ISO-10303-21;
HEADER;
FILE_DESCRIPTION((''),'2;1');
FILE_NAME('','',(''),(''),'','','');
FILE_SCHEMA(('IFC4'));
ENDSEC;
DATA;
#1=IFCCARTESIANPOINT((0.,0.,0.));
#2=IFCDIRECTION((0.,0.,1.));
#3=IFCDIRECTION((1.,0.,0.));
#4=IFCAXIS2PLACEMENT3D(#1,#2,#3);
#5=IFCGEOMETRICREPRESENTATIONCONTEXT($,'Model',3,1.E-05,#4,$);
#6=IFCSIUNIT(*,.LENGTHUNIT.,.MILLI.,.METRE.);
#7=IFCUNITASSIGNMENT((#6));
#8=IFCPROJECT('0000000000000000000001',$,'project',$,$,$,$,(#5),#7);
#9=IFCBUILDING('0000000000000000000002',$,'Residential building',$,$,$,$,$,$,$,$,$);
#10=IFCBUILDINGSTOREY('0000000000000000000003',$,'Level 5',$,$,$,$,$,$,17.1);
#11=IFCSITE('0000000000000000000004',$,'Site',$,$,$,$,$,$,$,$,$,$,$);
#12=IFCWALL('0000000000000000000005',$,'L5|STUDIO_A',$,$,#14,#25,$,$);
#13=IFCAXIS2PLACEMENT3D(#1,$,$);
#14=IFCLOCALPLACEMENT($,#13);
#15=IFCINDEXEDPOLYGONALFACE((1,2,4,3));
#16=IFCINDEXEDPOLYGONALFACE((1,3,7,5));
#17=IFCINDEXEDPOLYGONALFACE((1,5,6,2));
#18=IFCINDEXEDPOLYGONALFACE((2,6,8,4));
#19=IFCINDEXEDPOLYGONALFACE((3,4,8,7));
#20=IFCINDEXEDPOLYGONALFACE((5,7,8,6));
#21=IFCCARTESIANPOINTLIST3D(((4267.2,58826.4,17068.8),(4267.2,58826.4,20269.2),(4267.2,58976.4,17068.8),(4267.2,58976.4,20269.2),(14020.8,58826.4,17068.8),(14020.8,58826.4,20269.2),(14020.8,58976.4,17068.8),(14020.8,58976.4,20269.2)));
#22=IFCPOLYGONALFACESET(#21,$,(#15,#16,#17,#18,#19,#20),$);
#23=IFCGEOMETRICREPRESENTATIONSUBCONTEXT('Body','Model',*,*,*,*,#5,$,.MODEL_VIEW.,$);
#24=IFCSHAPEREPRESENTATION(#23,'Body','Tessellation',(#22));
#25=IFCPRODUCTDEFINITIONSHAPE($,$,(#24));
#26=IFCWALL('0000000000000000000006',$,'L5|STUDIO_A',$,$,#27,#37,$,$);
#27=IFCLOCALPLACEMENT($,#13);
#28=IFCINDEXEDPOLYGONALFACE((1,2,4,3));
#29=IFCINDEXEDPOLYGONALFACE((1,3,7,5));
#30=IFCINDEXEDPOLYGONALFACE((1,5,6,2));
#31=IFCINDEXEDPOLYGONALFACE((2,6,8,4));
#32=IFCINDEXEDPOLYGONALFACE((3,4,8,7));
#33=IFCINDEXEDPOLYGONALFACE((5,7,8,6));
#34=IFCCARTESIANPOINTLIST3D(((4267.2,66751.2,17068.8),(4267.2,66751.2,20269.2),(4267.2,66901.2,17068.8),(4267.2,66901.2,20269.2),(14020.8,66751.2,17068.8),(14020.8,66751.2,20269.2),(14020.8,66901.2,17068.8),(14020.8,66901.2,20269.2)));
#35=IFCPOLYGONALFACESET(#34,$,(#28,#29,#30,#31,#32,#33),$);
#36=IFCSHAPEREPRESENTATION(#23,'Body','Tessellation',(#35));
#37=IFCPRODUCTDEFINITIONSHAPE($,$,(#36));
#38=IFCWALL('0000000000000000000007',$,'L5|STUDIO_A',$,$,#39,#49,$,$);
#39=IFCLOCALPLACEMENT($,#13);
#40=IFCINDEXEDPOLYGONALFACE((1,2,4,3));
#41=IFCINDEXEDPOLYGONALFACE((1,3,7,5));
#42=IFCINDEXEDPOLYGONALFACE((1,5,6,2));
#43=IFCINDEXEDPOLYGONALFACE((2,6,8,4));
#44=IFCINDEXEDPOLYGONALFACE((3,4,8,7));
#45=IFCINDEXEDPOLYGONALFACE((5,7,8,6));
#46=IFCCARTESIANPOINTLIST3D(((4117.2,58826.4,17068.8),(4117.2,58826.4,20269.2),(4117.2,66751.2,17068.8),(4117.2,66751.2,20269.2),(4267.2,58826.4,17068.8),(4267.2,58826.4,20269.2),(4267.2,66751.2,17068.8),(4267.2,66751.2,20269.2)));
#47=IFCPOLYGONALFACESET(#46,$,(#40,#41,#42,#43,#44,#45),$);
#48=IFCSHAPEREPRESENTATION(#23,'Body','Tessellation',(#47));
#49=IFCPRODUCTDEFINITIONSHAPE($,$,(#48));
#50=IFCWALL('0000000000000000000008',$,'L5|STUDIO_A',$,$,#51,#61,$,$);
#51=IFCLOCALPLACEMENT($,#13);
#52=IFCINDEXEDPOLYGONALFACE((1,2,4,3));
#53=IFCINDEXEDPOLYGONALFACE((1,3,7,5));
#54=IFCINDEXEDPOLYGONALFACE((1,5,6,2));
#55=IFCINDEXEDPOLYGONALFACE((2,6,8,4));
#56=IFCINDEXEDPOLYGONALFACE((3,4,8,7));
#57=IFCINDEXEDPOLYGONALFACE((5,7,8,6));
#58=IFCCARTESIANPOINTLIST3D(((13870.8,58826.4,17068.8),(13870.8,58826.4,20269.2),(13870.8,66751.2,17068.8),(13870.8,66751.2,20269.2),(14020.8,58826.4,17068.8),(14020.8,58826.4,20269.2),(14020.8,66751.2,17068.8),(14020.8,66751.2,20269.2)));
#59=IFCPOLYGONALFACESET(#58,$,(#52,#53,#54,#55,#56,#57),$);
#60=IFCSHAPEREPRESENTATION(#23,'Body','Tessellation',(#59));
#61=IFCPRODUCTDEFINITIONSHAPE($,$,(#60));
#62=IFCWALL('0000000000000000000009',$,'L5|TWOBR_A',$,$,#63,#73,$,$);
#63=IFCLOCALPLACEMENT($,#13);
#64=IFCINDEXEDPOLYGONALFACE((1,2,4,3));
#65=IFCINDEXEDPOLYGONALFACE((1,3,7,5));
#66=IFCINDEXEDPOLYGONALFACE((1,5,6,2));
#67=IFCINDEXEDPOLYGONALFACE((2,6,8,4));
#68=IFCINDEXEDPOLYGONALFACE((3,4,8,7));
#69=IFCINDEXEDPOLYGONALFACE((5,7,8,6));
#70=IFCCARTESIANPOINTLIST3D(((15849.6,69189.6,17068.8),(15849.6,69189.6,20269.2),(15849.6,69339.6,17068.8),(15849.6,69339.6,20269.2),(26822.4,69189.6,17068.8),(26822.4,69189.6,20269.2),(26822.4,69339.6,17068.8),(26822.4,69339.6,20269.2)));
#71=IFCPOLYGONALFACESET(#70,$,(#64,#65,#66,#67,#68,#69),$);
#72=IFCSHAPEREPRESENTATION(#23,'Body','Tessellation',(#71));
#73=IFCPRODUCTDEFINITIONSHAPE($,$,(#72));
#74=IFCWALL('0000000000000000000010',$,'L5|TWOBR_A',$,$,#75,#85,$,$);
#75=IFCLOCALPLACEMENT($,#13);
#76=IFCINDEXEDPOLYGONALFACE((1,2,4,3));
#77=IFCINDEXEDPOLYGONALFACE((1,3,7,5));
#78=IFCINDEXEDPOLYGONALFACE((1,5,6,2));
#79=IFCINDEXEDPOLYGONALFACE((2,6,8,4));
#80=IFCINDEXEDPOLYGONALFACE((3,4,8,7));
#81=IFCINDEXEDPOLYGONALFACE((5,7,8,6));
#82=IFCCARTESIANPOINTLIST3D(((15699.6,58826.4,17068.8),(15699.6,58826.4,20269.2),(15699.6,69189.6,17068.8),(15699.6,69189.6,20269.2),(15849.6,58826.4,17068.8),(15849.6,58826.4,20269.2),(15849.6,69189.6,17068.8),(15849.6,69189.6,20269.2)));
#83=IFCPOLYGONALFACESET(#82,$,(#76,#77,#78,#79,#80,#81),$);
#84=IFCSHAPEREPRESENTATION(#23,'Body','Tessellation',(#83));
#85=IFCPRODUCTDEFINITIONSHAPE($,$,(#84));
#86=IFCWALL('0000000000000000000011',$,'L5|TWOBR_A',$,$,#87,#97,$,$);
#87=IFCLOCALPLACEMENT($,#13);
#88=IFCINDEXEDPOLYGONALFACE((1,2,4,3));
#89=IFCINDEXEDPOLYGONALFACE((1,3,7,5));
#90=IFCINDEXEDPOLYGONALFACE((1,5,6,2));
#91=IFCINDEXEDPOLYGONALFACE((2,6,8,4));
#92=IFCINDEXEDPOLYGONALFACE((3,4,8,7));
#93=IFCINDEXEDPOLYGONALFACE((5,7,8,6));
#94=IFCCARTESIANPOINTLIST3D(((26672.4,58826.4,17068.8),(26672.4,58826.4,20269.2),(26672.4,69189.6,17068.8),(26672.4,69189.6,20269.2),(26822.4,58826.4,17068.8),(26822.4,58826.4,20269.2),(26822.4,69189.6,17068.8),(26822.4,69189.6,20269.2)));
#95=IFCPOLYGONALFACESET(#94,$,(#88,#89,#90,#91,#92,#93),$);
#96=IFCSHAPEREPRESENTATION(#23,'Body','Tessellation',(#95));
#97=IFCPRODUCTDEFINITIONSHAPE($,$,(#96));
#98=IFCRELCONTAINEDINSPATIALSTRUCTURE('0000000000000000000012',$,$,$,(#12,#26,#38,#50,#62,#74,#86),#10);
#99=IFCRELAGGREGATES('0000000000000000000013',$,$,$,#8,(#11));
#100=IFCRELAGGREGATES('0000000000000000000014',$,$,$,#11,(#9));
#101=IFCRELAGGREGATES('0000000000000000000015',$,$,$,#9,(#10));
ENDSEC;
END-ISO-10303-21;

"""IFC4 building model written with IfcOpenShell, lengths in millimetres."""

from ifc_helpers import new_model, si_unit, frame, origin_with_axes, place, context, subcontext, project, spatial, indexed_curve, outline, extrude, element, save


model = new_model("IFC4")

# Units and contexts
model_context = context("Model", 3, precision=1e-05, world=origin_with_axes())
body_context = subcontext(model_context, "Body", "Model", "MODEL_VIEW")
ifc_project = project(units=[si_unit("LENGTHUNIT", "METRE", prefix="MILLI")], contexts=[model_context])

# Site, building, storey
site = spatial("IfcSite", under=ifc_project, Name="Site")
building = spatial("IfcBuilding", under=site, Name="Residential building")
storey = spatial("IfcBuildingStorey", under=building, Name="Level 5", Elevation=17.1)

# Walls
for number, where, z_axis, x_axis, name in (
    (1, (4267.2, 58826.4, 17068.8), (0.0, 0.0, 1.0), (1.0, 0.0, 0.0), "L5|STUDIO_A"),
    (2, (4267.2, 66751.2, 17068.8), (0.0, 0.0, 1.0), (1.0, 0.0, 0.0), "L5|STUDIO_A"),
):
    element("IfcWall", number, at=place(None, frame(where, z_axis=z_axis, x_axis=x_axis)), inside=storey, Name=name, context=body_context, shape_type="SweptSolid", body=[
        extrude(outline(indexed_curve([(0.0, 0.0), (0.0, 150.0), (9753.6, 150.0), (9753.6, 0.0), (0.0, 0.0)], self_intersect=False)), origin_with_axes(), (0.0, 0.0, 1.0), 3200.4),
    ])
for number, where, z_axis, x_axis, name in (
    (3, (4267.2, 58826.4, 17068.8), (0.0, 0.0, 1.0), (0.0, 1.0, 0.0), "L5|STUDIO_A"),
    (4, (14020.8, 58826.4, 17068.8), (0.0, 0.0, 1.0), (0.0, 1.0, 0.0), "L5|STUDIO_A"),
):
    element("IfcWall", number, at=place(None, frame(where, z_axis=z_axis, x_axis=x_axis)), inside=storey, Name=name, context=body_context, shape_type="SweptSolid", body=[
        extrude(outline(indexed_curve([(0.0, 0.0), (0.0, 150.0), (7924.8, 150.0), (7924.8, 0.0), (0.0, 0.0)], self_intersect=False)), origin_with_axes(), (0.0, 0.0, 1.0), 3200.4),
    ])
for number, where, z_axis, x_axis, name in (
    (5, (15849.6, 69189.6, 17068.8), (0.0, 0.0, 1.0), (1.0, 0.0, 0.0), "L5|TWOBR_A"),
):
    element("IfcWall", number, at=place(None, frame(where, z_axis=z_axis, x_axis=x_axis)), inside=storey, Name=name, context=body_context, shape_type="SweptSolid", body=[
        extrude(outline(indexed_curve([(0.0, 0.0), (0.0, 150.0), (10972.8, 150.0), (10972.8, 0.0), (0.0, 0.0)], self_intersect=False)), origin_with_axes(), (0.0, 0.0, 1.0), 3200.4),
    ])
for number, where, z_axis, x_axis, name in (
    (6, (15849.6, 58826.4, 17068.8), (0.0, 0.0, 1.0), (0.0, 1.0, 0.0), "L5|TWOBR_A"),
    (7, (26822.4, 58826.4, 17068.8), (0.0, 0.0, 1.0), (0.0, 1.0, 0.0), "L5|TWOBR_A"),
):
    element("IfcWall", number, at=place(None, frame(where, z_axis=z_axis, x_axis=x_axis)), inside=storey, Name=name, context=body_context, shape_type="SweptSolid", body=[
        extrude(outline(indexed_curve([(0.0, 0.0), (0.0, 150.0), (10363.2, 150.0), (10363.2, 0.0), (0.0, 0.0)], self_intersect=False)), origin_with_axes(), (0.0, 0.0, 1.0), 3200.4),
    ])

save(model, "model.ifc")
